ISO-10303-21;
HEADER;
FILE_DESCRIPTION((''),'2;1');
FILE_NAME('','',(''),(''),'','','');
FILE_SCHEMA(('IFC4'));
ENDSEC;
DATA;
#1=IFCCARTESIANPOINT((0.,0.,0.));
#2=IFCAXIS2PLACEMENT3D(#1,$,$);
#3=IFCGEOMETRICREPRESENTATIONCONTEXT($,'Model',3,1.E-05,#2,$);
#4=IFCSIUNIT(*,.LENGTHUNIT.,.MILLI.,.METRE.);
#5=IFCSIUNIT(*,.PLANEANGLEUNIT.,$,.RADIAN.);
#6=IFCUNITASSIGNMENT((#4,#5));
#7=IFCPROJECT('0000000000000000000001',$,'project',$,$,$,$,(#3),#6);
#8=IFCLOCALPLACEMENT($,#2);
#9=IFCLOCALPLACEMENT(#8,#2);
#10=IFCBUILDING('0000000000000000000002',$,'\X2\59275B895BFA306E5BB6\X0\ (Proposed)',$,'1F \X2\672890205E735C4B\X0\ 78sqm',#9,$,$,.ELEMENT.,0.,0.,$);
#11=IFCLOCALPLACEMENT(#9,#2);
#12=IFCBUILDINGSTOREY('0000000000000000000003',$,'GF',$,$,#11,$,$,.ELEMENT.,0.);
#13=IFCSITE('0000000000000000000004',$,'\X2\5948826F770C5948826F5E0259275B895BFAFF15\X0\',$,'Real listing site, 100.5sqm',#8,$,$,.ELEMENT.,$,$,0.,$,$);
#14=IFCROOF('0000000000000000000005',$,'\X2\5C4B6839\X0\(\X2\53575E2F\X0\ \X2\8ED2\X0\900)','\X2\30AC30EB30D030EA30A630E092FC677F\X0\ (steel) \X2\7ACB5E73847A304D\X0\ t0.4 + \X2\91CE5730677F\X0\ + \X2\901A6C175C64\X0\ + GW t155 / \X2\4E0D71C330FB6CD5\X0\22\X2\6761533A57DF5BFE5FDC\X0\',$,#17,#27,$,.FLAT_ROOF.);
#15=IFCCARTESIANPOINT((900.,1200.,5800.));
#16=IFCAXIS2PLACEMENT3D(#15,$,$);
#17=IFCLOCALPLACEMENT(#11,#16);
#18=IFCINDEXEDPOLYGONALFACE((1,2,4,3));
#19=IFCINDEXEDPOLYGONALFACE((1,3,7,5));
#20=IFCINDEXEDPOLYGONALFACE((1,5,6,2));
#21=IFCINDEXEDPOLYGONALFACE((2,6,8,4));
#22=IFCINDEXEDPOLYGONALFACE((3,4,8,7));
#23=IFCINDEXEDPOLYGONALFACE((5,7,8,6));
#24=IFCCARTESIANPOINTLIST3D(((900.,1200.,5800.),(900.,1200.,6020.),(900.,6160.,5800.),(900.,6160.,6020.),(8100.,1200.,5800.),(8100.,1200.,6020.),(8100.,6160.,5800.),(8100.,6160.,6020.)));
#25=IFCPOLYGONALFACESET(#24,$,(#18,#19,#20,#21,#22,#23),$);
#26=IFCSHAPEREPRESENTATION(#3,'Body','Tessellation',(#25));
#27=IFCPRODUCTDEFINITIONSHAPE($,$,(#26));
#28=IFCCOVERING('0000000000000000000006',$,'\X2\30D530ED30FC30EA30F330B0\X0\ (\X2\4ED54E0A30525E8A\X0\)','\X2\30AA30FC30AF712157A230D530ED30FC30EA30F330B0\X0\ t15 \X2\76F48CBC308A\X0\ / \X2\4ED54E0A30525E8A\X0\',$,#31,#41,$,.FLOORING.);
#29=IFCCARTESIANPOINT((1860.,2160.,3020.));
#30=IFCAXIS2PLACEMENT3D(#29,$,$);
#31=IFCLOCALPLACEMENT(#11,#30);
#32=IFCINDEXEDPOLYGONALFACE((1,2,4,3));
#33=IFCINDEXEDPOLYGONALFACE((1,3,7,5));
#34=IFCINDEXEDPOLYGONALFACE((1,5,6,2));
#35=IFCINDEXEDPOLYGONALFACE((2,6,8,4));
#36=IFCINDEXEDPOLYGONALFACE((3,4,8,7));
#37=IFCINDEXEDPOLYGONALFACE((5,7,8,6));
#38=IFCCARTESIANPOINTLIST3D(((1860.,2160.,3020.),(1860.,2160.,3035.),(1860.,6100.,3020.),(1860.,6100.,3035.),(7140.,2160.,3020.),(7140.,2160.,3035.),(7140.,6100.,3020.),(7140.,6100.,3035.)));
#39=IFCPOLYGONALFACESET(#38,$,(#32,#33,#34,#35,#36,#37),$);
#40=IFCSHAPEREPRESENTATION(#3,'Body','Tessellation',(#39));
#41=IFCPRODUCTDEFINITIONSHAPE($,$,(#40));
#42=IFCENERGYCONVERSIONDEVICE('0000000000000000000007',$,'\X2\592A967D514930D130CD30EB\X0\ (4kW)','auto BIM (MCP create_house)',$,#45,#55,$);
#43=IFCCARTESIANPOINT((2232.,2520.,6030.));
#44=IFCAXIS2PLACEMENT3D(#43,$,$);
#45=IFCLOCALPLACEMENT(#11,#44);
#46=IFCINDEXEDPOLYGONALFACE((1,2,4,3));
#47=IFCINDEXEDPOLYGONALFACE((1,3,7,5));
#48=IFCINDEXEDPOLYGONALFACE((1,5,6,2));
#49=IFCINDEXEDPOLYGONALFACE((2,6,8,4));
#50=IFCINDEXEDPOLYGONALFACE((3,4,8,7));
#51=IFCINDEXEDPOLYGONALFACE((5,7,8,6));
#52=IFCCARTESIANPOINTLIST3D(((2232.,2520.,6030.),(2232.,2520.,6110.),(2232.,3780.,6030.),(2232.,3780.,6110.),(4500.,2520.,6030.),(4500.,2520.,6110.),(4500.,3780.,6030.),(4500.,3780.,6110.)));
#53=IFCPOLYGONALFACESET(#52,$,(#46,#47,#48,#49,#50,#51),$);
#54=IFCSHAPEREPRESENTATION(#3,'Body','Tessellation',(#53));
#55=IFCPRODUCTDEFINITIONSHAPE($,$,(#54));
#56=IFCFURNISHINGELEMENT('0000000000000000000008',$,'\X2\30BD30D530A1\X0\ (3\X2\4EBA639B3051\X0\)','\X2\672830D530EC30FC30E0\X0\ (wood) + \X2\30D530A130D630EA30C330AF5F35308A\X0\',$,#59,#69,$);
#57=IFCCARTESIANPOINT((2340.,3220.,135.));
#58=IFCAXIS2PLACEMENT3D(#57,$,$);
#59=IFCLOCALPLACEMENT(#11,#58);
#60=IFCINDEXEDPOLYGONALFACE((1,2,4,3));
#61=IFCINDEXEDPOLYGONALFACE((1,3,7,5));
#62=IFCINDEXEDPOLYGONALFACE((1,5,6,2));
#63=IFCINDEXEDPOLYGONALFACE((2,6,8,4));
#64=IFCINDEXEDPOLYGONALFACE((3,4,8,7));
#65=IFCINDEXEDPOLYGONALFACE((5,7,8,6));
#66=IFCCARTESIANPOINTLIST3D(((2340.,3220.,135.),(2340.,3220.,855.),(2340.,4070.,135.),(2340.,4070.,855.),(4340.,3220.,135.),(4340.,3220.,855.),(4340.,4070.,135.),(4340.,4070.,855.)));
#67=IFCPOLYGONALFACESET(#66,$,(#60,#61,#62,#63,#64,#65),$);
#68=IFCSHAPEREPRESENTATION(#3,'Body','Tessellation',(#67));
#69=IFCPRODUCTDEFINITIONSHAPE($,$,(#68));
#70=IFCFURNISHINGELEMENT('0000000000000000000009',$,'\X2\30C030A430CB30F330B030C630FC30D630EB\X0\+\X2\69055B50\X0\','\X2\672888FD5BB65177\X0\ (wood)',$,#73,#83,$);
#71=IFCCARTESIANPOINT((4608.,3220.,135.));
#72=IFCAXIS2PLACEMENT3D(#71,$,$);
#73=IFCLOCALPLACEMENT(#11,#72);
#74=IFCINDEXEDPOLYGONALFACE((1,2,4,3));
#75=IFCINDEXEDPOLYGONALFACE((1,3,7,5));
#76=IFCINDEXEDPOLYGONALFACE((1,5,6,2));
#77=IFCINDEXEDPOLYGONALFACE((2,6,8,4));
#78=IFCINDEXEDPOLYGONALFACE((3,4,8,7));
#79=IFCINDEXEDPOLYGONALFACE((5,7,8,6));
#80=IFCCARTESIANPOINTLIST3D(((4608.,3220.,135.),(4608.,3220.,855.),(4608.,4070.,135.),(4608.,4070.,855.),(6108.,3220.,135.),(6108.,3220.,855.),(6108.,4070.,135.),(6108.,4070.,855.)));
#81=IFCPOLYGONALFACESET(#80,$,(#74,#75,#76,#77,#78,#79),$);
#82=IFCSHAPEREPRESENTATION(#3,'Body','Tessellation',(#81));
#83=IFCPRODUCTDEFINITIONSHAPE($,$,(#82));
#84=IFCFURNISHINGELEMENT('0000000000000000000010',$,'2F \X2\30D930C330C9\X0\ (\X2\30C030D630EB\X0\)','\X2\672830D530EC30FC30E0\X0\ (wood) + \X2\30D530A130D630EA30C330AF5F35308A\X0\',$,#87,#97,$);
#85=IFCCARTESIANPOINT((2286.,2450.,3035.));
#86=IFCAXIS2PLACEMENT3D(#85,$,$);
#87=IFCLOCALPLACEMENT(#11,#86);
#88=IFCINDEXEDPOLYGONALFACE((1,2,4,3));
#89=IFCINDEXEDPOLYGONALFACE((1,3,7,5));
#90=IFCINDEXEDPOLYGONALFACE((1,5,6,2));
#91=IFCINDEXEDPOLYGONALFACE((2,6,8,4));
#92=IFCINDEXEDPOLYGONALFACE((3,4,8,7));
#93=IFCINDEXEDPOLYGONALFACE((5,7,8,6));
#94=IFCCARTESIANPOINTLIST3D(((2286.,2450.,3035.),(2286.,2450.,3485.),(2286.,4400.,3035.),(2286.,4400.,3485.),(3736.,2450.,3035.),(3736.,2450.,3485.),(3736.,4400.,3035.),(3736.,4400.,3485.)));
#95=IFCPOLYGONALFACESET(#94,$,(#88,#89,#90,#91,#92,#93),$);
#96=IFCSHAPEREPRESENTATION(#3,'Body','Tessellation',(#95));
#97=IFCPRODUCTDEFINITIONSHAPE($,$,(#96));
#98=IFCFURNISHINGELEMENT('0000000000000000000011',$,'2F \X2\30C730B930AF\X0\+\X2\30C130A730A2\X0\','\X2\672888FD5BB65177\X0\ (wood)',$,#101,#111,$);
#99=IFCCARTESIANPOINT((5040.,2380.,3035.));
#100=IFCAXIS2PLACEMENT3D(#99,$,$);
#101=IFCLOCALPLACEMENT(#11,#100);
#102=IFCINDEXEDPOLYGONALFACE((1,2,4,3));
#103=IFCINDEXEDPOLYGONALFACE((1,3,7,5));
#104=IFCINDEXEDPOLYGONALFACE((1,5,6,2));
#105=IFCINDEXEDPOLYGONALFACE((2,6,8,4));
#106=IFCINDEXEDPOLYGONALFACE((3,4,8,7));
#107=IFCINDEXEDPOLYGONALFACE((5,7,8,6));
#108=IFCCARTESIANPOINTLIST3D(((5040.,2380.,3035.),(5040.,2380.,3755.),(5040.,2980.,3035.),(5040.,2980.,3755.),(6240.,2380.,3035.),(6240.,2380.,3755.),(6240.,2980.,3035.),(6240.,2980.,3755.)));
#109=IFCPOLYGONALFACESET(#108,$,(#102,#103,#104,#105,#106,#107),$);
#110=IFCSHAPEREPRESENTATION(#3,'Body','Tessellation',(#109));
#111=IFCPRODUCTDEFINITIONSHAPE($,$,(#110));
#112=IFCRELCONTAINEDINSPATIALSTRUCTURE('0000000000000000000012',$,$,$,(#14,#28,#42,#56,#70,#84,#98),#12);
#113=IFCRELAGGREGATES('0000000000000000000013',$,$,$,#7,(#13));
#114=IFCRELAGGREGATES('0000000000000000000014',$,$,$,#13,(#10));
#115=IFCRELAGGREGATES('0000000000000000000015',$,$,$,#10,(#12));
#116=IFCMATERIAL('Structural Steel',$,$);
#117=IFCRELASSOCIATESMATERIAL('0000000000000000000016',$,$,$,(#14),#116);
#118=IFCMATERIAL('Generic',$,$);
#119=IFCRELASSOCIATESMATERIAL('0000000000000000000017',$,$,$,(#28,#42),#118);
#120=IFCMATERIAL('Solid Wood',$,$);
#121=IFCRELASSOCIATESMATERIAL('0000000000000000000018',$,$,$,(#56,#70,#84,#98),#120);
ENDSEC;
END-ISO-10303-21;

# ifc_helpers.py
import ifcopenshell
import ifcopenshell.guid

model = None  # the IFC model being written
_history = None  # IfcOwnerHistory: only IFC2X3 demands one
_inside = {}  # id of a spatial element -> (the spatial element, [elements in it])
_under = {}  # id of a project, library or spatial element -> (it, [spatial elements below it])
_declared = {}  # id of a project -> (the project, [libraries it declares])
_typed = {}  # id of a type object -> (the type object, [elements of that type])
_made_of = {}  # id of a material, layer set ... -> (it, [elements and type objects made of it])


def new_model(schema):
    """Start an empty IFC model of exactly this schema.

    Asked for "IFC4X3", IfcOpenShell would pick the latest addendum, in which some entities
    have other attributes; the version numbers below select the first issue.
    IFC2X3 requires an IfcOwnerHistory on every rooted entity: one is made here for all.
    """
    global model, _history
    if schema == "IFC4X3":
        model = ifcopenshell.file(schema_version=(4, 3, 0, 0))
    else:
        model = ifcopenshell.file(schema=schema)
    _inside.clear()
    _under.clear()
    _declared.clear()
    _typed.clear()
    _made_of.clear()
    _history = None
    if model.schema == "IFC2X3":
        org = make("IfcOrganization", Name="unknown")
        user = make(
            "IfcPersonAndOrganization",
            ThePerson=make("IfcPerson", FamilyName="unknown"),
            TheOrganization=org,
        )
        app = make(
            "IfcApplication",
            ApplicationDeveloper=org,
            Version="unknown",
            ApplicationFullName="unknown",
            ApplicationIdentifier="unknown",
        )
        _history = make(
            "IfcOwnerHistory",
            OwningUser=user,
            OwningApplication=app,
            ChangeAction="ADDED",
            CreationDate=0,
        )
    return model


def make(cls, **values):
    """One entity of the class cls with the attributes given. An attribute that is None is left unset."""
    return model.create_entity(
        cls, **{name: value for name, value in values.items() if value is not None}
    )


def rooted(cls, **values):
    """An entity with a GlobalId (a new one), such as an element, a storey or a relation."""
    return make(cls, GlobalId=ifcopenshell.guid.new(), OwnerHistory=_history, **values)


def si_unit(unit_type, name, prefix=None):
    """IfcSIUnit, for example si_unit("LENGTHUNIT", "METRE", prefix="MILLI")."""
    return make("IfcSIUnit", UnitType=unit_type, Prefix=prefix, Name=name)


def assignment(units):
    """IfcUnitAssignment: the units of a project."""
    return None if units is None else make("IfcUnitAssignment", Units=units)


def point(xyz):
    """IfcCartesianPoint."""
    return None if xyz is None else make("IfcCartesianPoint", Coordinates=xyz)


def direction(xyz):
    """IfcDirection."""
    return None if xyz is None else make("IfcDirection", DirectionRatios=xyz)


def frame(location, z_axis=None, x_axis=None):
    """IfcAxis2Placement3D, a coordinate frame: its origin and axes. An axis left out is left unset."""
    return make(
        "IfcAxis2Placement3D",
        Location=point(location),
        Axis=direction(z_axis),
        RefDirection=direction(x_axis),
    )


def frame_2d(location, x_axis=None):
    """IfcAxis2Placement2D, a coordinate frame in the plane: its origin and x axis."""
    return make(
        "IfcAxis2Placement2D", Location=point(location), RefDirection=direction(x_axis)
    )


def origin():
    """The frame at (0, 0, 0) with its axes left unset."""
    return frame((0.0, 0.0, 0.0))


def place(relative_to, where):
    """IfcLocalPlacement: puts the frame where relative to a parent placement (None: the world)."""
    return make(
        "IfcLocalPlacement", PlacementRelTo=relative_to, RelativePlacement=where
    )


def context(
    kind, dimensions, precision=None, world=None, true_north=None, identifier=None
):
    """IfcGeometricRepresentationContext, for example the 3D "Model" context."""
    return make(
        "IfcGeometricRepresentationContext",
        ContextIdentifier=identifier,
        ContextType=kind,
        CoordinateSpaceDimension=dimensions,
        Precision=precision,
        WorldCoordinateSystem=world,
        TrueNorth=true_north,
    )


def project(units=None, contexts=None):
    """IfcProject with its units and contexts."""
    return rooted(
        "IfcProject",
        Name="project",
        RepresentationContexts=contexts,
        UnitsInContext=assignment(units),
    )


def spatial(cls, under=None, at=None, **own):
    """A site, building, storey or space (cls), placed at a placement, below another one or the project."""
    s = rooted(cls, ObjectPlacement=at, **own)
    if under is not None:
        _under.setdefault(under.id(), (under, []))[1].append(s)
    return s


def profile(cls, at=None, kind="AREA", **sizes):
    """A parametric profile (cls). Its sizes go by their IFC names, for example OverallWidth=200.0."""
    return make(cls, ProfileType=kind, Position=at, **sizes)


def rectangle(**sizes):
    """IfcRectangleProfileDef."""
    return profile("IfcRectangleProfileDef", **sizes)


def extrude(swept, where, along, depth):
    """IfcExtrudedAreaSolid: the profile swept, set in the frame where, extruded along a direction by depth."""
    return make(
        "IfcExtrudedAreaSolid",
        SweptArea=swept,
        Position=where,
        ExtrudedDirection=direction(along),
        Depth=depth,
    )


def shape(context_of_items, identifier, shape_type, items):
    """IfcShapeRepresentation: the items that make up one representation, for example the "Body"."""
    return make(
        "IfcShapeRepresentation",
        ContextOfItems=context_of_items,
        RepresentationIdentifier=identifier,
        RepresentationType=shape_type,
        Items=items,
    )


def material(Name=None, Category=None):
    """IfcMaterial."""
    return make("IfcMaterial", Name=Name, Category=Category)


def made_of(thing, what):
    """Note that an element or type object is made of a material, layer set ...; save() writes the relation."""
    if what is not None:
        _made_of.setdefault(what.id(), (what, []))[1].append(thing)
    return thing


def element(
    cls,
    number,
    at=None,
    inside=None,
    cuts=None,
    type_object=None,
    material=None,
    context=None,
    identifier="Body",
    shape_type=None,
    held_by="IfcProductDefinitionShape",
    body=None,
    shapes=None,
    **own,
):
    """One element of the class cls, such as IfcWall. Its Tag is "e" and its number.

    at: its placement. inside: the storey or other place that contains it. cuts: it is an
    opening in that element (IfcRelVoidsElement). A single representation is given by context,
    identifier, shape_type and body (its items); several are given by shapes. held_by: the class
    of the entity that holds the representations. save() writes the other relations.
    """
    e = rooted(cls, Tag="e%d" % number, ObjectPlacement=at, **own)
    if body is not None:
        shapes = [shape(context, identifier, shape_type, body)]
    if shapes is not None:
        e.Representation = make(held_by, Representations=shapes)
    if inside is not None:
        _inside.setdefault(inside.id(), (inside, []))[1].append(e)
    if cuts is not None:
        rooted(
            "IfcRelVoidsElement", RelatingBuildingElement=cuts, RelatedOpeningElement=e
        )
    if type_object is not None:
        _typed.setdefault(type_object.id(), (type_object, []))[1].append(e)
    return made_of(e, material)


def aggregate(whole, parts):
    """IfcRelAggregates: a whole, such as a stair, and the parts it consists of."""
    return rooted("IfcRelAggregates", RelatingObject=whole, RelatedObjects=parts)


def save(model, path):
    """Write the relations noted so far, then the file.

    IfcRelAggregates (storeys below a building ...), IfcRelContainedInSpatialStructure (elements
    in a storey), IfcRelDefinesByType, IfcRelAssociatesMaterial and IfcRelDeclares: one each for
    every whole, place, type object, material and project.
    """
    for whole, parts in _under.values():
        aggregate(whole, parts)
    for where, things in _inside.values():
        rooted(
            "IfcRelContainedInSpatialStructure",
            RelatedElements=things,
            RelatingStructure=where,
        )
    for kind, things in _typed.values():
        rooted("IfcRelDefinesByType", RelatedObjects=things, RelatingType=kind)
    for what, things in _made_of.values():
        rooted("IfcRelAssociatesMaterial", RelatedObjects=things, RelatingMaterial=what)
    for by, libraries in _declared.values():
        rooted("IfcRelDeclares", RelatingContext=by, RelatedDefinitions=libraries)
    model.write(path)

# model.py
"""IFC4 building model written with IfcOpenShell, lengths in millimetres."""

from ifc_helpers import new_model, si_unit, frame, frame_2d, origin, place, context, project, spatial, rectangle, extrude, material, element, save


model = new_model("IFC4")

# Units and contexts
model_context = context("Model", 3, precision=1e-05, world=origin())
ifc_project = project(units=[si_unit("LENGTHUNIT", "METRE", prefix="MILLI"), si_unit("PLANEANGLEUNIT", "RADIAN")], contexts=[model_context])

# Site, building, storey
site_placement = place(None, origin())
site = spatial("IfcSite", under=ifc_project, at=site_placement, Name="奈良県奈良市大安寺５", ObjectType="Real listing site, 100.5sqm", CompositionType="ELEMENT", RefElevation=0.0)
building_placement = place(site_placement, origin())
building = spatial("IfcBuilding", under=site, at=building_placement, Name="大安寺の家 (Proposed)", ObjectType="1F 木造平屋 78sqm", CompositionType="ELEMENT", ElevationOfRefHeight=0.0, ElevationOfTerrain=0.0)
storey_placement = place(building_placement, origin())
storey = spatial("IfcBuildingStorey", under=building, at=storey_placement, Name="GF", CompositionType="ELEMENT", Elevation=0.0)

# Shared definitions
ifc_material_1 = material(Name="Solid Wood")

# Shared definitions
ifc_material_2 = material(Name="Generic")

# Roof
ifc_material_3 = material(Name="Structural Steel")
for number, where, name in (
    (1, (900.0, 1200.0, 5800.0), "屋根(南帯 軒900)"),
):
    element("IfcRoof", number, at=place(storey_placement, frame(where)), inside=storey, material=ifc_material_3, Name=name, Description="ガルバリウム鋼板 (steel) 立平葺き t0.4 + 野地板 + 通気層 + GW t155 / 不燃・法22条区域対応", PredefinedType="FLAT_ROOF", context=model_context, shape_type="SweptSolid", body=[
        extrude(rectangle(XDim=7200.0, YDim=4960.0, at=frame_2d((3600.0, 2480.0))), frame((900.0, 1200.0, 5800.0)), (0.0, 0.0, 1.0), 220.0),
    ])

# Covering
covering_placement = place(storey_placement, frame((1860.0, 2160.0, 3020.0)))
element("IfcCovering", 2, at=covering_placement, inside=storey, material=ifc_material_2, Name="フローリング (仕上げ床)", Description="オーク無垢フローリング t15 直貼り / 仕上げ床", PredefinedType="FLOORING", context=model_context, shape_type="SweptSolid", body=[
    extrude(rectangle(XDim=5280.0, YDim=3940.0, at=frame_2d((2640.0, 1970.0))), frame((1860.0, 2160.0, 3020.0)), (0.0, 0.0, 1.0), 15.0),
])

# Energy conversion device
energy_conversion_device_placement = place(storey_placement, frame((2232.0, 2520.0, 6030.0)))
element("IfcEnergyConversionDevice", 3, at=energy_conversion_device_placement, inside=storey, material=ifc_material_2, Name="太陽光パネル (4kW)", Description="auto BIM (MCP create_house)", context=model_context, shape_type="SweptSolid", body=[
    extrude(rectangle(XDim=2268.0, YDim=1260.0, at=frame_2d((1134.0, 630.0))), frame((2232.0, 2520.0, 6030.0)), (0.0, 0.0, 1.0), 80.0),
])

# Furnishing elements
furnishing_1_placement = place(storey_placement, frame((2340.0, 3220.0, 135.0)))
element("IfcFurnishingElement", 4, at=furnishing_1_placement, inside=storey, material=ifc_material_1, Name="ソファ (3人掛け)", Description="木フレーム (wood) + ファブリック張り", context=model_context, shape_type="SweptSolid", body=[
    extrude(rectangle(XDim=2000.0, YDim=850.0, at=frame_2d((1000.0, 425.0))), frame((2340.0, 3220.0, 135.0)), (0.0, 0.0, 1.0), 720.0),
])
furnishing_2_placement = place(storey_placement, frame((4608.0, 3220.0, 135.0)))
element("IfcFurnishingElement", 5, at=furnishing_2_placement, inside=storey, material=ifc_material_1, Name="ダイニングテーブル+椅子", Description="木製家具 (wood)", context=model_context, shape_type="SweptSolid", body=[
    extrude(rectangle(XDim=1500.0, YDim=850.0, at=frame_2d((750.0, 425.0))), frame((4608.0, 3220.0, 135.0)), (0.0, 0.0, 1.0), 720.0),
])
furnishing_3_placement = place(storey_placement, frame((2286.0, 2450.0, 3035.0)))
element("IfcFurnishingElement", 6, at=furnishing_3_placement, inside=storey, material=ifc_material_1, Name="2F ベッド (ダブル)", Description="木フレーム (wood) + ファブリック張り", context=model_context, shape_type="SweptSolid", body=[
    extrude(rectangle(XDim=1450.0, YDim=1950.0, at=frame_2d((725.0, 975.0))), frame((2286.0, 2450.0, 3035.0)), (0.0, 0.0, 1.0), 450.0),
])
furnishing_4_placement = place(storey_placement, frame((5040.0, 2380.0, 3035.0)))
element("IfcFurnishingElement", 7, at=furnishing_4_placement, inside=storey, material=ifc_material_1, Name="2F デスク+チェア", Description="木製家具 (wood)", context=model_context, shape_type="SweptSolid", body=[
    extrude(rectangle(XDim=1200.0, YDim=600.0, at=frame_2d((600.0, 300.0))), frame((5040.0, 2380.0, 3035.0)), (0.0, 0.0, 1.0), 720.0),
])

save(model, "model.ifc")
